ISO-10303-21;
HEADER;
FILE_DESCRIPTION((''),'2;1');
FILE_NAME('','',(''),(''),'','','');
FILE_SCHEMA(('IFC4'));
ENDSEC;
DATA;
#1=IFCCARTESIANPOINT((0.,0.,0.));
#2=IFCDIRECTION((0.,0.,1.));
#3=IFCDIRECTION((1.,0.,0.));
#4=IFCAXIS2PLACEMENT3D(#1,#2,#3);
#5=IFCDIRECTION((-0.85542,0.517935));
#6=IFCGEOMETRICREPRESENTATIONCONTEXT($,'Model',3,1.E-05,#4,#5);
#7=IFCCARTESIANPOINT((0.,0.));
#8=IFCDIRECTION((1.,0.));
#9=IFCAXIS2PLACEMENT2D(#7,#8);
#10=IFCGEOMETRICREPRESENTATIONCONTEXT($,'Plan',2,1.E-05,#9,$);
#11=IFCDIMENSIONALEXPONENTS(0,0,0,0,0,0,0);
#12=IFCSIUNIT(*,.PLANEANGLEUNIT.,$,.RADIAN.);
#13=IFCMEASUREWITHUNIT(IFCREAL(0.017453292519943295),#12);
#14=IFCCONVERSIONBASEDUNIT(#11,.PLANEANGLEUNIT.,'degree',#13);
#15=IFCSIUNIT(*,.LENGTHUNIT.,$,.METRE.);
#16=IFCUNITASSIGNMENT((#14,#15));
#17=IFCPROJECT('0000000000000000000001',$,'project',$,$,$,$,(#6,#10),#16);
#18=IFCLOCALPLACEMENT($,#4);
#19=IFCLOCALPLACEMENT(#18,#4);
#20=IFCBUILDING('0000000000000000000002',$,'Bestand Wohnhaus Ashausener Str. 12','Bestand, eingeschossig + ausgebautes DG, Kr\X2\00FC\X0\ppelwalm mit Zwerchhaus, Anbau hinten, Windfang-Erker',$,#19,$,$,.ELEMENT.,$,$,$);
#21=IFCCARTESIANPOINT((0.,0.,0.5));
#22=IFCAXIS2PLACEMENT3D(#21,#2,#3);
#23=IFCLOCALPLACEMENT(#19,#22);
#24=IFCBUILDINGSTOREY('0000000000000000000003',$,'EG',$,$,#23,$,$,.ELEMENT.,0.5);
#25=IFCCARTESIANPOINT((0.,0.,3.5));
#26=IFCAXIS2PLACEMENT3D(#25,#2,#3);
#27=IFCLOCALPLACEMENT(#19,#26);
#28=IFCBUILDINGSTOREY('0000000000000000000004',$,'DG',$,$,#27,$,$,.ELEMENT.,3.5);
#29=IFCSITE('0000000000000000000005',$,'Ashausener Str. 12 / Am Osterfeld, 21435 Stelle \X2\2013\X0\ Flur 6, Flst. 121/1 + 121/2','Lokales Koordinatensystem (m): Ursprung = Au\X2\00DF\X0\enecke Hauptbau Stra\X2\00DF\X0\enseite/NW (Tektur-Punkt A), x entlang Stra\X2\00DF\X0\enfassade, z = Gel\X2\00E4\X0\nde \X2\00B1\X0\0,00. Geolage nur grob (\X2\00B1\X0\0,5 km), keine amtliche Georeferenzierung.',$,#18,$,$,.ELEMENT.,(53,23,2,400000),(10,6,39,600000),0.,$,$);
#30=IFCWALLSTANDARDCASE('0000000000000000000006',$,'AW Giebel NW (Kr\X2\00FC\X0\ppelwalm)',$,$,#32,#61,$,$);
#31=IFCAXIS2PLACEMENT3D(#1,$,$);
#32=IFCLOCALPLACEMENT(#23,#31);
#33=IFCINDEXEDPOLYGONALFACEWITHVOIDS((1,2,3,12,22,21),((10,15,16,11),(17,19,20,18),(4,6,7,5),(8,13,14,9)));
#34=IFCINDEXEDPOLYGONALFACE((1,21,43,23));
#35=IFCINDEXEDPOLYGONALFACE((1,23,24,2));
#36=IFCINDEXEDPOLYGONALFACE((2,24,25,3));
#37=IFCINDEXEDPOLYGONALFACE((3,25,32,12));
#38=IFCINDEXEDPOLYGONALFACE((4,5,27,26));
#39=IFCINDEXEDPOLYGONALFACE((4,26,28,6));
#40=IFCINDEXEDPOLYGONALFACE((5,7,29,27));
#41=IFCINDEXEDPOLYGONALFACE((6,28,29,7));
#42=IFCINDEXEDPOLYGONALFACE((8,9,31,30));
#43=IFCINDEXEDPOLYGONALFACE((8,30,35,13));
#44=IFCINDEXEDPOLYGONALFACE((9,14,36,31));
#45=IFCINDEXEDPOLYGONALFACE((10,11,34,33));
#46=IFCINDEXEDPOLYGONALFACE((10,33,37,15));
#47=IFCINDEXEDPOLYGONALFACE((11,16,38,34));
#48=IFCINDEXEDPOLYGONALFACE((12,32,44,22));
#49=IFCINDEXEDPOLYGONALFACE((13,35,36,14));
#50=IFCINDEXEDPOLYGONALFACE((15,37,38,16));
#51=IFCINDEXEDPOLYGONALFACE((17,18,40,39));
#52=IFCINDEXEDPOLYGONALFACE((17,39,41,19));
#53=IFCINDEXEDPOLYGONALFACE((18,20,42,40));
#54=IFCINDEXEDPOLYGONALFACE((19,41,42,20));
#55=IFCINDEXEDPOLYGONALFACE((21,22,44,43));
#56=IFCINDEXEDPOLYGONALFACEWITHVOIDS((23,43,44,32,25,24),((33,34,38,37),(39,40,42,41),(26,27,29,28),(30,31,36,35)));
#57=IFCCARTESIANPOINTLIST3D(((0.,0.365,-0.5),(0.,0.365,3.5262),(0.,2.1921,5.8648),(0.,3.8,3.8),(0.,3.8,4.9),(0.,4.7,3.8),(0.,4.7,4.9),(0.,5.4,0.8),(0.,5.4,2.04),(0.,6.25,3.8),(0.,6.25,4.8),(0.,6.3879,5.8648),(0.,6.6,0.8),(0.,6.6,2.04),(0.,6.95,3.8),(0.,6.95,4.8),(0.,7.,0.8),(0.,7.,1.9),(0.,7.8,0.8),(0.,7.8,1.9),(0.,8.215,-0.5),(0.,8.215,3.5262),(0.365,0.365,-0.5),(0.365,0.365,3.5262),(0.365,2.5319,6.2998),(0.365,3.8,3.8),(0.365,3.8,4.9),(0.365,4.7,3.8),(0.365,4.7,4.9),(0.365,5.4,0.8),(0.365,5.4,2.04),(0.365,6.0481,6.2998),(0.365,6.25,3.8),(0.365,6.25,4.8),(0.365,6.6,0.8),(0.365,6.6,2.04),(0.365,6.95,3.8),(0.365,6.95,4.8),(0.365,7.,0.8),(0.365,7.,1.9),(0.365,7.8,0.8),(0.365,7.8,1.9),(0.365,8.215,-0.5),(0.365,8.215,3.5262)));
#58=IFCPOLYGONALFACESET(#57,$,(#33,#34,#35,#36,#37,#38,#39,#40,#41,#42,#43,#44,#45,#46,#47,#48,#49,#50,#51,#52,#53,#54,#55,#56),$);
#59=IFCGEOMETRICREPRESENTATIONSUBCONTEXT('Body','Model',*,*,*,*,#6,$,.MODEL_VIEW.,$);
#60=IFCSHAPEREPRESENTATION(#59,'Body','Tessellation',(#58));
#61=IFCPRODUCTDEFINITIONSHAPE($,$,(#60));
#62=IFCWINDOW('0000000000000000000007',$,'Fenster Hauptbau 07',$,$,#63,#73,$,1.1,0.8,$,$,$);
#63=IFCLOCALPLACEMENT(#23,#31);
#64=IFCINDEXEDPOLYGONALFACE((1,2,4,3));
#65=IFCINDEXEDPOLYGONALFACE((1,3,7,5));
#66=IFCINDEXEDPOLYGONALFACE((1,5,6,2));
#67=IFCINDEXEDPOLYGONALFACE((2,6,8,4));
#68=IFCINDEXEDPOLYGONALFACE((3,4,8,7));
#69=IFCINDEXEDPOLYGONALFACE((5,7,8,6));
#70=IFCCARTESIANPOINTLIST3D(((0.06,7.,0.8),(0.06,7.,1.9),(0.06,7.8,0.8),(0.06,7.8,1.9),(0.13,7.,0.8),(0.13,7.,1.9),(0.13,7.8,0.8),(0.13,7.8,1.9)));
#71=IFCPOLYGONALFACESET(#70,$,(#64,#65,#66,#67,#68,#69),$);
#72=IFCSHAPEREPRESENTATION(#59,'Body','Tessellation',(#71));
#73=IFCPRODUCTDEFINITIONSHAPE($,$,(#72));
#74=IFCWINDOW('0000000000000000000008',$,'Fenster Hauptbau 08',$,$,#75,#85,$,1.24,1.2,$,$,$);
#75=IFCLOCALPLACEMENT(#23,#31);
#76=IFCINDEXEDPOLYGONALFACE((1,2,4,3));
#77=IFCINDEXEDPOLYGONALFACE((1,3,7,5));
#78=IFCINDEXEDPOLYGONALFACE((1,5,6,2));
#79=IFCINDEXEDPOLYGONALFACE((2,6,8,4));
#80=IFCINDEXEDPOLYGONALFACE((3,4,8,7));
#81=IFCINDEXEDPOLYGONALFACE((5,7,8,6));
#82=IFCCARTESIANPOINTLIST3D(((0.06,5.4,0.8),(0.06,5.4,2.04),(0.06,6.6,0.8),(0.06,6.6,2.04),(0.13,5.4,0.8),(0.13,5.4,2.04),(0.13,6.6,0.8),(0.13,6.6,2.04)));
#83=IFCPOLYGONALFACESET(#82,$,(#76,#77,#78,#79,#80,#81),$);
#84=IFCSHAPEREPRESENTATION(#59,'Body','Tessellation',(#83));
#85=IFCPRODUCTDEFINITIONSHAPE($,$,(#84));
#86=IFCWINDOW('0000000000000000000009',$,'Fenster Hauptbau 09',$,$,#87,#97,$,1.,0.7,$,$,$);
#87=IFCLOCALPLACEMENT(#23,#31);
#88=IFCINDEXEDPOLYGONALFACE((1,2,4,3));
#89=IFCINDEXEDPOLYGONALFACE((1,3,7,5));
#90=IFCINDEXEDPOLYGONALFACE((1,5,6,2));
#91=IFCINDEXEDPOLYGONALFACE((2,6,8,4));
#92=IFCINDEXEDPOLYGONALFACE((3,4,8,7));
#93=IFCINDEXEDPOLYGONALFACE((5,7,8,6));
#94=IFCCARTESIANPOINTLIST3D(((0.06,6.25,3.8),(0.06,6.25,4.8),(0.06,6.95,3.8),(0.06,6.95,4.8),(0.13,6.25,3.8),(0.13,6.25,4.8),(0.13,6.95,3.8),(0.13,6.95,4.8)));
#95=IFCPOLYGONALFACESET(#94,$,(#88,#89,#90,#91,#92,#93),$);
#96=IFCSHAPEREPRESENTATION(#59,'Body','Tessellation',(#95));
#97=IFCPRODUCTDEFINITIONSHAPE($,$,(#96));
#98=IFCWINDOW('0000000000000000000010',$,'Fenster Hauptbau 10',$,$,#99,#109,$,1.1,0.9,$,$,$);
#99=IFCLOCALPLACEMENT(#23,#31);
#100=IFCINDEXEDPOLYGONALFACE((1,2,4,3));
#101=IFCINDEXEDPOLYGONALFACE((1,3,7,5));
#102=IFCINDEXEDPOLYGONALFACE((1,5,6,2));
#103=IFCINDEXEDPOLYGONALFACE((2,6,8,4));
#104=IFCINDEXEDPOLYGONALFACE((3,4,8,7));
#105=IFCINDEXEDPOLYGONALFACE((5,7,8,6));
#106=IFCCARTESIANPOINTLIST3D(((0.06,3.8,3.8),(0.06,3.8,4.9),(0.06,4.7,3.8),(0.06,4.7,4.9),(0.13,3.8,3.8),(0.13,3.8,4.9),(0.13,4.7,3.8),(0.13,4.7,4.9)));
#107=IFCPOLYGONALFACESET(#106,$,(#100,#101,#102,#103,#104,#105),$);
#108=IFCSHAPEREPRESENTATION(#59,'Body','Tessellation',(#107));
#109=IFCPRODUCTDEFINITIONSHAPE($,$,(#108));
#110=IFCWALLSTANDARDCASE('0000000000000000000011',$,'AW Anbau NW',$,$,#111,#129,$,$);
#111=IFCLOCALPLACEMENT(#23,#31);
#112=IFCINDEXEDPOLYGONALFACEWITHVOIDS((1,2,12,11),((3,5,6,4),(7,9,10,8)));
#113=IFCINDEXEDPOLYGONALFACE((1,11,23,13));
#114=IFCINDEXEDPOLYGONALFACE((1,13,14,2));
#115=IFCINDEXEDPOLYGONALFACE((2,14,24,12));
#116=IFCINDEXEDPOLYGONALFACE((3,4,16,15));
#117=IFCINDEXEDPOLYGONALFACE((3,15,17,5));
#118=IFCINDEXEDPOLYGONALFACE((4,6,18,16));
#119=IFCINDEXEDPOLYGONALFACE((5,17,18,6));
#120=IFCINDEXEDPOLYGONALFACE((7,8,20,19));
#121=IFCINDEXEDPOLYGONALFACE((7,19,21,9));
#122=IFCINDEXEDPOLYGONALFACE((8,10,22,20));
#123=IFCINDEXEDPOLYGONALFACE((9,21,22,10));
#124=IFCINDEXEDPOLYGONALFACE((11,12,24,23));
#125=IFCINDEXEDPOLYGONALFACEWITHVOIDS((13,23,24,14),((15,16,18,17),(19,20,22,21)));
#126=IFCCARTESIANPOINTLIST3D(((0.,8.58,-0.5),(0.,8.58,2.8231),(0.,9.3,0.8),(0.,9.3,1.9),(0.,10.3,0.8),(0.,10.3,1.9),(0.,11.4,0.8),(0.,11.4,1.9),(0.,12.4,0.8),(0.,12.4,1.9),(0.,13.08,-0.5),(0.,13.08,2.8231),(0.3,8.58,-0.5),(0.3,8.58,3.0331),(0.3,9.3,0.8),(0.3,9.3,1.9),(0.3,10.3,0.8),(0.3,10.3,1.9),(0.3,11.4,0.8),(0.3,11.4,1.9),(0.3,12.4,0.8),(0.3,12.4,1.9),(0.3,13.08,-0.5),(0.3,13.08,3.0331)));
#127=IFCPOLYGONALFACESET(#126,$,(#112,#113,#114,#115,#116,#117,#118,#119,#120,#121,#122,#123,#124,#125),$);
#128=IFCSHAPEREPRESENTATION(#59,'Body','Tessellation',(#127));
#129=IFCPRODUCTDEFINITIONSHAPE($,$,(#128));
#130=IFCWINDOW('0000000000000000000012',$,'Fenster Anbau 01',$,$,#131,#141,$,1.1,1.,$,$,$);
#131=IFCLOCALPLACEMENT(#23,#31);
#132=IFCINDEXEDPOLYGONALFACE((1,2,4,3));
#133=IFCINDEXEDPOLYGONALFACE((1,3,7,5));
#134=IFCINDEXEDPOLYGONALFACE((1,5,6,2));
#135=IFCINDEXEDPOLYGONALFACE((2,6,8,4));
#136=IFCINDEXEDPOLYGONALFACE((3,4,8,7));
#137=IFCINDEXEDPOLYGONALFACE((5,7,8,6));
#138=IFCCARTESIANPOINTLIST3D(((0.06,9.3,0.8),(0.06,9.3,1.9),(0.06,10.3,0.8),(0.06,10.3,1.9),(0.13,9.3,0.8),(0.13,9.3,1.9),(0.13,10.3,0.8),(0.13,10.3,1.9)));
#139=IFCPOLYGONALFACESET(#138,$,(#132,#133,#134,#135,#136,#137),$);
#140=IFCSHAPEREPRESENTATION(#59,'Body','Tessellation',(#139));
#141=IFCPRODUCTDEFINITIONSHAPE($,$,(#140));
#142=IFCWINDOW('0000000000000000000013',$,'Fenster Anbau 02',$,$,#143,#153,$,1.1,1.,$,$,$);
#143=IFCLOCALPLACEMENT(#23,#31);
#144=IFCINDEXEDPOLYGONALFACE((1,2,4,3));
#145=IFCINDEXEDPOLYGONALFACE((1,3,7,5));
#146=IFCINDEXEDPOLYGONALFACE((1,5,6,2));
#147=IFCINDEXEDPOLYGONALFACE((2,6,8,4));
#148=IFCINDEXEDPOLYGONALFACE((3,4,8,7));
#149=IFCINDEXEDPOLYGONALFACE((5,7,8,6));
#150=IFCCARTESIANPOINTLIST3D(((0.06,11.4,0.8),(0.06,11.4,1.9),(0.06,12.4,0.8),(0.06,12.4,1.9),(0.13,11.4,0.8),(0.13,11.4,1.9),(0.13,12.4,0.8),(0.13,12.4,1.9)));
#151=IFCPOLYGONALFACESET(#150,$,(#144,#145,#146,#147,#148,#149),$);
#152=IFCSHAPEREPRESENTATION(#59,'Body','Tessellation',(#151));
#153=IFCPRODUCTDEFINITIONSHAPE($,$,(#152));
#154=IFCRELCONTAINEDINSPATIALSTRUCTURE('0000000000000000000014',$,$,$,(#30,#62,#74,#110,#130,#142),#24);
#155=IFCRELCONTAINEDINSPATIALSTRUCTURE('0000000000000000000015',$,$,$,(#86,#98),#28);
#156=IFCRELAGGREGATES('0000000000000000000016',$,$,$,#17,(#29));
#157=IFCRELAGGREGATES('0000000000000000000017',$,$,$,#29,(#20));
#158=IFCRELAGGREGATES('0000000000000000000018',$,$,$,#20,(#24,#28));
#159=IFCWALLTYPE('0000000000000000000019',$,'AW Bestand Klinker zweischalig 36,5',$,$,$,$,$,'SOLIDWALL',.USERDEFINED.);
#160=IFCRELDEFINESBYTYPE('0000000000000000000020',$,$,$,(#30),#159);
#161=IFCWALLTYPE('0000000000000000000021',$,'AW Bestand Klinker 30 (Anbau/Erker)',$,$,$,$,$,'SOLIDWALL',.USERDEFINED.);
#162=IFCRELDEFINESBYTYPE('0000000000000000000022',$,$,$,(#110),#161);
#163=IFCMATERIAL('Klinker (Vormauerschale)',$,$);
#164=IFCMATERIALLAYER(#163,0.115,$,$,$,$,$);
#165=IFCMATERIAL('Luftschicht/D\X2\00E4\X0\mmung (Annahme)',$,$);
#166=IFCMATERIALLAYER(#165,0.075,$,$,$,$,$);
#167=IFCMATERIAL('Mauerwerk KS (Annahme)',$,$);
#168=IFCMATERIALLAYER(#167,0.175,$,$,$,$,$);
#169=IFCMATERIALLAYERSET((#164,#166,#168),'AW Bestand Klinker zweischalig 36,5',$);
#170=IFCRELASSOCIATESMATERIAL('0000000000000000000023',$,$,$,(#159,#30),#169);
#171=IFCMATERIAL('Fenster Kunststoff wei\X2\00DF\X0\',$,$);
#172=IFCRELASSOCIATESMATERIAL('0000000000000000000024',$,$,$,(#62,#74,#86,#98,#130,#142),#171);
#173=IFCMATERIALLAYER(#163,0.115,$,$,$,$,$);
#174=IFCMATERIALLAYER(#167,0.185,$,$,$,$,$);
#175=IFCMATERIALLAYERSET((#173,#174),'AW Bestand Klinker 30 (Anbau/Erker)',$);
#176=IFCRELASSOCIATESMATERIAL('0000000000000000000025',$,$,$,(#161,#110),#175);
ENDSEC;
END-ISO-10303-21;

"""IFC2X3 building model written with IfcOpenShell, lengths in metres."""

from ifc_helpers import new_model, entity, si_unit, converted_unit, direction, frame, origin_with_axes, origin_2d_with_axis, place, context, subcontext, project, spatial, polyline, outline, extrude, clip, halfspace, material, layer, layer_set, layer_usage, type_object, element, fill, save


model = new_model("IFC2X3")

# Units and contexts
model_context = context("Model", 3, precision=1e-05, world=origin_with_axes(), true_north=direction((-0.85542, 0.517935)))
plan_context = context("Plan", 2, precision=1e-05, world=origin_2d_with_axis())
body_context = subcontext(model_context, "Body", "Model", "MODEL_VIEW")
ifc_project = project(units=[converted_unit("PLANEANGLEUNIT", "degree", entity("IfcReal", 0.017453292519943295), si_unit("PLANEANGLEUNIT", "RADIAN"), dimensions=[0, 0, 0, 0, 0, 0, 0]), si_unit("LENGTHUNIT", "METRE")], contexts=[model_context, plan_context])

# Site, building, storey
site_placement = place(None, origin_with_axes())
site = spatial("IfcSite", under=ifc_project, at=site_placement, Name="Ashausener Str. 12 / Am Osterfeld, 21435 Stelle – Flur 6, Flst. 121/1 + 121/2", Description="Lokales Koordinatensystem (m): Ursprung = Außenecke Hauptbau Straßenseite/NW (Tektur-Punkt A), x entlang Straßenfassade, z = Gelände ±0,00. Geolage nur grob (±0,5 km), keine amtliche Georeferenzierung.", CompositionType="ELEMENT", RefLatitude=(53, 23, 2, 400000), RefLongitude=(10, 6, 39, 600000), RefElevation=0.0)
building_placement = place(site_placement, origin_with_axes())
building = spatial("IfcBuilding", under=site, at=building_placement, Name="Bestand Wohnhaus Ashausener Str. 12", Description="Bestand, eingeschossig + ausgebautes DG, Krüppelwalm mit Zwerchhaus, Anbau hinten, Windfang-Erker", CompositionType="ELEMENT")
storey_1_placement = place(building_placement, frame((0.0, 0.0, 0.5), z_axis=(0.0, 0.0, 1.0), x_axis=(1.0, 0.0, 0.0)))
storey_1 = spatial("IfcBuildingStorey", under=building, at=storey_1_placement, Name="EG", CompositionType="ELEMENT", Elevation=0.5)

# Wall, openings, windows
ifc_material_1 = material(Name="Klinker (Vormauerschale)")
ifc_layer_1 = layer(ifc_material_1, 0.115)
ifc_material_2 = material(Name="Luftschicht/Dämmung (Annahme)")
ifc_layer_2 = layer(ifc_material_2, 0.075)
ifc_material_3 = material(Name="Mauerwerk KS (Annahme)")
ifc_layer_3 = layer(ifc_material_3, 0.175)
ifc_layer_set_1 = layer_set([ifc_layer_1, ifc_layer_2, ifc_layer_3], Name="AW Bestand Klinker zweischalig 36,5")
ifc_layer_usage_1 = layer_usage(ifc_layer_set_1, "AXIS2", "POSITIVE", 0.0)
wall_type_1 = type_object("IfcWallType", Name="AW Bestand Klinker zweischalig 36,5", ElementType="SOLIDWALL", PredefinedType="USERDEFINED", material=ifc_layer_set_1)
wall_1_placement = place(storey_1_placement, frame((0.0, 8.215, -0.5), z_axis=(0.0, 0.0, 1.0), x_axis=(0.0, -1.0, 0.0)))
wall_1 = element("IfcWallStandardCase", 1, at=wall_1_placement, inside=storey_1, type_object=wall_type_1, material=ifc_layer_usage_1, Name="AW Giebel NW (Krüppelwalm)", context=body_context, shape_type="Clipping", body=[
    clip(clip(clip(clip(extrude(outline(polyline([(0.0, 0.0), (0.0, 0.365), (7.85, 0.365), (7.85, 0.0), (0.0, 0.0)])), origin_with_axes(), (0.0, 0.0, 1.0), 12.0), halfspace(frame((8.215, 11.87, 5.9), z_axis=(0.0, 0.76604, 0.64279), x_axis=(1.0, 0.0, 0.0)), False)), halfspace(frame((8.215, -0.39, 5.9), z_axis=(0.0, -0.76604, 0.64279), x_axis=(-1.0, 0.0, 0.0)), False)), halfspace(frame((3.925, 0.0, 9.05), z_axis=(-0.78801, 0.0, 0.61566), x_axis=(0.0, 1.0, 0.0)), False)), halfspace(frame((3.925, 0.0, 9.05), z_axis=(0.78801, 0.0, 0.61566), x_axis=(0.0, -1.0, 0.0)), False)),
])
opening_1_placement = place(wall_1_placement, frame((0.415, -0.1, 1.3), z_axis=(0.0, 0.0, 1.0), x_axis=(1.0, 0.0, 0.0)))
opening_1 = element("IfcOpeningElement", 2, at=opening_1_placement, cuts=wall_1, context=body_context, shape_type="SweptSolid", body=[
    extrude(outline(polyline([(0.0, 0.0), (0.0, 0.565), (0.8, 0.565), (0.8, 0.0), (0.0, 0.0)])), origin_with_axes(), (0.0, 0.0, 1.0), 1.1),
])
opening_2_placement = place(wall_1_placement, frame((1.615, -0.1, 1.3), z_axis=(0.0, 0.0, 1.0), x_axis=(1.0, 0.0, 0.0)))
opening_2 = element("IfcOpeningElement", 3, at=opening_2_placement, cuts=wall_1, context=body_context, shape_type="SweptSolid", body=[
    extrude(outline(polyline([(0.0, 0.0), (0.0, 0.565), (1.2, 0.565), (1.2, 0.0), (0.0, 0.0)])), origin_with_axes(), (0.0, 0.0, 1.0), 1.24),
])
opening_3_placement = place(wall_1_placement, frame((1.265, -0.1, 4.3), z_axis=(0.0, 0.0, 1.0), x_axis=(1.0, 0.0, 0.0)))
opening_3 = element("IfcOpeningElement", 4, at=opening_3_placement, cuts=wall_1, context=body_context, shape_type="SweptSolid", body=[
    extrude(outline(polyline([(0.0, 0.0), (0.0, 0.565), (0.7, 0.565), (0.7, 0.0), (0.0, 0.0)])), origin_with_axes(), (0.0, 0.0, 1.0), 1.0),
])
opening_4_placement = place(wall_1_placement, frame((3.515, -0.1, 4.3), z_axis=(0.0, 0.0, 1.0), x_axis=(1.0, 0.0, 0.0)))
opening_4 = element("IfcOpeningElement", 5, at=opening_4_placement, cuts=wall_1, context=body_context, shape_type="SweptSolid", body=[
    extrude(outline(polyline([(0.0, 0.0), (0.0, 0.565), (0.9, 0.565), (0.9, 0.0), (0.0, 0.0)])), origin_with_axes(), (0.0, 0.0, 1.0), 1.1),
])
ifc_material_4 = material(Name="Fenster Kunststoff weiß")
window_1_placement = place(storey_1_placement, frame((0.06, 7.8, 0.8), z_axis=(0.0, 0.0, 1.0), x_axis=(0.0, -1.0, 0.0)))
window_1 = element("IfcWindow", 6, at=window_1_placement, inside=storey_1, material=ifc_material_4, Name="Fenster Hauptbau 07", OverallHeight=1.1, OverallWidth=0.8, context=body_context, shape_type="SweptSolid", body=[
    extrude(outline(polyline([(0.0, 0.0), (0.0, 0.07), (0.8, 0.07), (0.8, 0.0), (0.0, 0.0)])), origin_with_axes(), (0.0, 0.0, 1.0), 1.1),
])
fill(opening_1, window_1)
window_2_placement = place(storey_1_placement, frame((0.06, 6.6, 0.8), z_axis=(0.0, 0.0, 1.0), x_axis=(0.0, -1.0, 0.0)))
window_2 = element("IfcWindow", 7, at=window_2_placement, inside=storey_1, material=ifc_material_4, Name="Fenster Hauptbau 08", OverallHeight=1.24, OverallWidth=1.2, context=body_context, shape_type="SweptSolid", body=[
    extrude(outline(polyline([(0.0, 0.0), (0.0, 0.07), (1.2, 0.07), (1.2, 0.0), (0.0, 0.0)])), origin_with_axes(), (0.0, 0.0, 1.0), 1.24),
])
fill(opening_2, window_2)

# Shared definitions
storey_2_placement = place(building_placement, frame((0.0, 0.0, 3.5), z_axis=(0.0, 0.0, 1.0), x_axis=(1.0, 0.0, 0.0)))
storey_2 = spatial("IfcBuildingStorey", under=building, at=storey_2_placement, Name="DG", CompositionType="ELEMENT", Elevation=3.5)

# Windows
window_3_placement = place(storey_2_placement, frame((0.06, 6.95, 0.8), z_axis=(0.0, 0.0, 1.0), x_axis=(0.0, -1.0, 0.0)))
window_3 = element("IfcWindow", 8, at=window_3_placement, inside=storey_2, material=ifc_material_4, Name="Fenster Hauptbau 09", OverallHeight=1.0, OverallWidth=0.7, context=body_context, shape_type="SweptSolid", body=[
    extrude(outline(polyline([(0.0, 0.0), (0.0, 0.07), (0.7, 0.07), (0.7, 0.0), (0.0, 0.0)])), origin_with_axes(), (0.0, 0.0, 1.0), 1.0),
])
fill(opening_3, window_3)
window_4_placement = place(storey_2_placement, frame((0.06, 4.7, 0.8), z_axis=(0.0, 0.0, 1.0), x_axis=(0.0, -1.0, 0.0)))
window_4 = element("IfcWindow", 9, at=window_4_placement, inside=storey_2, material=ifc_material_4, Name="Fenster Hauptbau 10", OverallHeight=1.1, OverallWidth=0.9, context=body_context, shape_type="SweptSolid", body=[
    extrude(outline(polyline([(0.0, 0.0), (0.0, 0.07), (0.9, 0.07), (0.9, 0.0), (0.0, 0.0)])), origin_with_axes(), (0.0, 0.0, 1.0), 1.1),
])
fill(opening_4, window_4)

# Wall, openings, windows
ifc_layer_4 = layer(ifc_material_1, 0.115)
ifc_layer_5 = layer(ifc_material_3, 0.185)
ifc_layer_set_2 = layer_set([ifc_layer_4, ifc_layer_5], Name="AW Bestand Klinker 30 (Anbau/Erker)")
ifc_layer_usage_2 = layer_usage(ifc_layer_set_2, "AXIS2", "POSITIVE", 0.0)
wall_type_2 = type_object("IfcWallType", Name="AW Bestand Klinker 30 (Anbau/Erker)", ElementType="SOLIDWALL", PredefinedType="USERDEFINED", material=ifc_layer_set_2)
wall_2_placement = place(storey_1_placement, frame((0.0, 13.08, -0.5), z_axis=(0.0, 0.0, 1.0), x_axis=(0.0, -1.0, 0.0)))
wall_2 = element("IfcWallStandardCase", 10, at=wall_2_placement, inside=storey_1, type_object=wall_type_2, material=ifc_layer_usage_2, Name="AW Anbau NW", context=body_context, shape_type="Clipping", body=[
    clip(clip(extrude(outline(polyline([(0.0, 0.0), (0.0, 0.3), (4.5, 0.3), (4.5, 0.0), (0.0, 0.0)])), origin_with_axes(), (0.0, 0.0, 1.0), 8.0), halfspace(frame((13.08, 4.29, 3.05), z_axis=(0.0, 0.57358, 0.81915), x_axis=(1.0, 0.0, 0.0)), False)), halfspace(frame((13.08, -0.39, 3.05), z_axis=(0.0, -0.57358, 0.81915), x_axis=(-1.0, 0.0, 0.0)), False)),
])
opening_5_placement = place(wall_2_placement, frame((2.78, -0.1, 1.3), z_axis=(0.0, 0.0, 1.0), x_axis=(1.0, 0.0, 0.0)))
opening_5 = element("IfcOpeningElement", 11, at=opening_5_placement, cuts=wall_2, context=body_context, shape_type="SweptSolid", body=[
    extrude(outline(polyline([(0.0, 0.0), (0.0, 0.5), (1.0, 0.5), (1.0, 0.0), (0.0, 0.0)])), origin_with_axes(), (0.0, 0.0, 1.0), 1.1),
])
opening_6_placement = place(wall_2_placement, frame((0.68, -0.1, 1.3), z_axis=(0.0, 0.0, 1.0), x_axis=(1.0, 0.0, 0.0)))
opening_6 = element("IfcOpeningElement", 12, at=opening_6_placement, cuts=wall_2, context=body_context, shape_type="SweptSolid", body=[
    extrude(outline(polyline([(0.0, 0.0), (0.0, 0.5), (1.0, 0.5), (1.0, 0.0), (0.0, 0.0)])), origin_with_axes(), (0.0, 0.0, 1.0), 1.1),
])
window_5_placement = place(storey_1_placement, frame((0.06, 10.3, 0.8), z_axis=(0.0, 0.0, 1.0), x_axis=(0.0, -1.0, 0.0)))
window_5 = element("IfcWindow", 13, at=window_5_placement, inside=storey_1, material=ifc_material_4, Name="Fenster Anbau 01", OverallHeight=1.1, OverallWidth=1.0, context=body_context, shape_type="SweptSolid", body=[
    extrude(outline(polyline([(0.0, 0.0), (0.0, 0.07), (1.0, 0.07), (1.0, 0.0), (0.0, 0.0)])), origin_with_axes(), (0.0, 0.0, 1.0), 1.1),
])
fill(opening_5, window_5)
window_6_placement = place(storey_1_placement, frame((0.06, 12.4, 0.8), z_axis=(0.0, 0.0, 1.0), x_axis=(0.0, -1.0, 0.0)))
window_6 = element("IfcWindow", 14, at=window_6_placement, inside=storey_1, material=ifc_material_4, Name="Fenster Anbau 02", OverallHeight=1.1, OverallWidth=1.0, context=body_context, shape_type="SweptSolid", body=[
    extrude(outline(polyline([(0.0, 0.0), (0.0, 0.07), (1.0, 0.07), (1.0, 0.0), (0.0, 0.0)])), origin_with_axes(), (0.0, 0.0, 1.0), 1.1),
])
fill(opening_6, window_6)

save(model, "model.ifc")
